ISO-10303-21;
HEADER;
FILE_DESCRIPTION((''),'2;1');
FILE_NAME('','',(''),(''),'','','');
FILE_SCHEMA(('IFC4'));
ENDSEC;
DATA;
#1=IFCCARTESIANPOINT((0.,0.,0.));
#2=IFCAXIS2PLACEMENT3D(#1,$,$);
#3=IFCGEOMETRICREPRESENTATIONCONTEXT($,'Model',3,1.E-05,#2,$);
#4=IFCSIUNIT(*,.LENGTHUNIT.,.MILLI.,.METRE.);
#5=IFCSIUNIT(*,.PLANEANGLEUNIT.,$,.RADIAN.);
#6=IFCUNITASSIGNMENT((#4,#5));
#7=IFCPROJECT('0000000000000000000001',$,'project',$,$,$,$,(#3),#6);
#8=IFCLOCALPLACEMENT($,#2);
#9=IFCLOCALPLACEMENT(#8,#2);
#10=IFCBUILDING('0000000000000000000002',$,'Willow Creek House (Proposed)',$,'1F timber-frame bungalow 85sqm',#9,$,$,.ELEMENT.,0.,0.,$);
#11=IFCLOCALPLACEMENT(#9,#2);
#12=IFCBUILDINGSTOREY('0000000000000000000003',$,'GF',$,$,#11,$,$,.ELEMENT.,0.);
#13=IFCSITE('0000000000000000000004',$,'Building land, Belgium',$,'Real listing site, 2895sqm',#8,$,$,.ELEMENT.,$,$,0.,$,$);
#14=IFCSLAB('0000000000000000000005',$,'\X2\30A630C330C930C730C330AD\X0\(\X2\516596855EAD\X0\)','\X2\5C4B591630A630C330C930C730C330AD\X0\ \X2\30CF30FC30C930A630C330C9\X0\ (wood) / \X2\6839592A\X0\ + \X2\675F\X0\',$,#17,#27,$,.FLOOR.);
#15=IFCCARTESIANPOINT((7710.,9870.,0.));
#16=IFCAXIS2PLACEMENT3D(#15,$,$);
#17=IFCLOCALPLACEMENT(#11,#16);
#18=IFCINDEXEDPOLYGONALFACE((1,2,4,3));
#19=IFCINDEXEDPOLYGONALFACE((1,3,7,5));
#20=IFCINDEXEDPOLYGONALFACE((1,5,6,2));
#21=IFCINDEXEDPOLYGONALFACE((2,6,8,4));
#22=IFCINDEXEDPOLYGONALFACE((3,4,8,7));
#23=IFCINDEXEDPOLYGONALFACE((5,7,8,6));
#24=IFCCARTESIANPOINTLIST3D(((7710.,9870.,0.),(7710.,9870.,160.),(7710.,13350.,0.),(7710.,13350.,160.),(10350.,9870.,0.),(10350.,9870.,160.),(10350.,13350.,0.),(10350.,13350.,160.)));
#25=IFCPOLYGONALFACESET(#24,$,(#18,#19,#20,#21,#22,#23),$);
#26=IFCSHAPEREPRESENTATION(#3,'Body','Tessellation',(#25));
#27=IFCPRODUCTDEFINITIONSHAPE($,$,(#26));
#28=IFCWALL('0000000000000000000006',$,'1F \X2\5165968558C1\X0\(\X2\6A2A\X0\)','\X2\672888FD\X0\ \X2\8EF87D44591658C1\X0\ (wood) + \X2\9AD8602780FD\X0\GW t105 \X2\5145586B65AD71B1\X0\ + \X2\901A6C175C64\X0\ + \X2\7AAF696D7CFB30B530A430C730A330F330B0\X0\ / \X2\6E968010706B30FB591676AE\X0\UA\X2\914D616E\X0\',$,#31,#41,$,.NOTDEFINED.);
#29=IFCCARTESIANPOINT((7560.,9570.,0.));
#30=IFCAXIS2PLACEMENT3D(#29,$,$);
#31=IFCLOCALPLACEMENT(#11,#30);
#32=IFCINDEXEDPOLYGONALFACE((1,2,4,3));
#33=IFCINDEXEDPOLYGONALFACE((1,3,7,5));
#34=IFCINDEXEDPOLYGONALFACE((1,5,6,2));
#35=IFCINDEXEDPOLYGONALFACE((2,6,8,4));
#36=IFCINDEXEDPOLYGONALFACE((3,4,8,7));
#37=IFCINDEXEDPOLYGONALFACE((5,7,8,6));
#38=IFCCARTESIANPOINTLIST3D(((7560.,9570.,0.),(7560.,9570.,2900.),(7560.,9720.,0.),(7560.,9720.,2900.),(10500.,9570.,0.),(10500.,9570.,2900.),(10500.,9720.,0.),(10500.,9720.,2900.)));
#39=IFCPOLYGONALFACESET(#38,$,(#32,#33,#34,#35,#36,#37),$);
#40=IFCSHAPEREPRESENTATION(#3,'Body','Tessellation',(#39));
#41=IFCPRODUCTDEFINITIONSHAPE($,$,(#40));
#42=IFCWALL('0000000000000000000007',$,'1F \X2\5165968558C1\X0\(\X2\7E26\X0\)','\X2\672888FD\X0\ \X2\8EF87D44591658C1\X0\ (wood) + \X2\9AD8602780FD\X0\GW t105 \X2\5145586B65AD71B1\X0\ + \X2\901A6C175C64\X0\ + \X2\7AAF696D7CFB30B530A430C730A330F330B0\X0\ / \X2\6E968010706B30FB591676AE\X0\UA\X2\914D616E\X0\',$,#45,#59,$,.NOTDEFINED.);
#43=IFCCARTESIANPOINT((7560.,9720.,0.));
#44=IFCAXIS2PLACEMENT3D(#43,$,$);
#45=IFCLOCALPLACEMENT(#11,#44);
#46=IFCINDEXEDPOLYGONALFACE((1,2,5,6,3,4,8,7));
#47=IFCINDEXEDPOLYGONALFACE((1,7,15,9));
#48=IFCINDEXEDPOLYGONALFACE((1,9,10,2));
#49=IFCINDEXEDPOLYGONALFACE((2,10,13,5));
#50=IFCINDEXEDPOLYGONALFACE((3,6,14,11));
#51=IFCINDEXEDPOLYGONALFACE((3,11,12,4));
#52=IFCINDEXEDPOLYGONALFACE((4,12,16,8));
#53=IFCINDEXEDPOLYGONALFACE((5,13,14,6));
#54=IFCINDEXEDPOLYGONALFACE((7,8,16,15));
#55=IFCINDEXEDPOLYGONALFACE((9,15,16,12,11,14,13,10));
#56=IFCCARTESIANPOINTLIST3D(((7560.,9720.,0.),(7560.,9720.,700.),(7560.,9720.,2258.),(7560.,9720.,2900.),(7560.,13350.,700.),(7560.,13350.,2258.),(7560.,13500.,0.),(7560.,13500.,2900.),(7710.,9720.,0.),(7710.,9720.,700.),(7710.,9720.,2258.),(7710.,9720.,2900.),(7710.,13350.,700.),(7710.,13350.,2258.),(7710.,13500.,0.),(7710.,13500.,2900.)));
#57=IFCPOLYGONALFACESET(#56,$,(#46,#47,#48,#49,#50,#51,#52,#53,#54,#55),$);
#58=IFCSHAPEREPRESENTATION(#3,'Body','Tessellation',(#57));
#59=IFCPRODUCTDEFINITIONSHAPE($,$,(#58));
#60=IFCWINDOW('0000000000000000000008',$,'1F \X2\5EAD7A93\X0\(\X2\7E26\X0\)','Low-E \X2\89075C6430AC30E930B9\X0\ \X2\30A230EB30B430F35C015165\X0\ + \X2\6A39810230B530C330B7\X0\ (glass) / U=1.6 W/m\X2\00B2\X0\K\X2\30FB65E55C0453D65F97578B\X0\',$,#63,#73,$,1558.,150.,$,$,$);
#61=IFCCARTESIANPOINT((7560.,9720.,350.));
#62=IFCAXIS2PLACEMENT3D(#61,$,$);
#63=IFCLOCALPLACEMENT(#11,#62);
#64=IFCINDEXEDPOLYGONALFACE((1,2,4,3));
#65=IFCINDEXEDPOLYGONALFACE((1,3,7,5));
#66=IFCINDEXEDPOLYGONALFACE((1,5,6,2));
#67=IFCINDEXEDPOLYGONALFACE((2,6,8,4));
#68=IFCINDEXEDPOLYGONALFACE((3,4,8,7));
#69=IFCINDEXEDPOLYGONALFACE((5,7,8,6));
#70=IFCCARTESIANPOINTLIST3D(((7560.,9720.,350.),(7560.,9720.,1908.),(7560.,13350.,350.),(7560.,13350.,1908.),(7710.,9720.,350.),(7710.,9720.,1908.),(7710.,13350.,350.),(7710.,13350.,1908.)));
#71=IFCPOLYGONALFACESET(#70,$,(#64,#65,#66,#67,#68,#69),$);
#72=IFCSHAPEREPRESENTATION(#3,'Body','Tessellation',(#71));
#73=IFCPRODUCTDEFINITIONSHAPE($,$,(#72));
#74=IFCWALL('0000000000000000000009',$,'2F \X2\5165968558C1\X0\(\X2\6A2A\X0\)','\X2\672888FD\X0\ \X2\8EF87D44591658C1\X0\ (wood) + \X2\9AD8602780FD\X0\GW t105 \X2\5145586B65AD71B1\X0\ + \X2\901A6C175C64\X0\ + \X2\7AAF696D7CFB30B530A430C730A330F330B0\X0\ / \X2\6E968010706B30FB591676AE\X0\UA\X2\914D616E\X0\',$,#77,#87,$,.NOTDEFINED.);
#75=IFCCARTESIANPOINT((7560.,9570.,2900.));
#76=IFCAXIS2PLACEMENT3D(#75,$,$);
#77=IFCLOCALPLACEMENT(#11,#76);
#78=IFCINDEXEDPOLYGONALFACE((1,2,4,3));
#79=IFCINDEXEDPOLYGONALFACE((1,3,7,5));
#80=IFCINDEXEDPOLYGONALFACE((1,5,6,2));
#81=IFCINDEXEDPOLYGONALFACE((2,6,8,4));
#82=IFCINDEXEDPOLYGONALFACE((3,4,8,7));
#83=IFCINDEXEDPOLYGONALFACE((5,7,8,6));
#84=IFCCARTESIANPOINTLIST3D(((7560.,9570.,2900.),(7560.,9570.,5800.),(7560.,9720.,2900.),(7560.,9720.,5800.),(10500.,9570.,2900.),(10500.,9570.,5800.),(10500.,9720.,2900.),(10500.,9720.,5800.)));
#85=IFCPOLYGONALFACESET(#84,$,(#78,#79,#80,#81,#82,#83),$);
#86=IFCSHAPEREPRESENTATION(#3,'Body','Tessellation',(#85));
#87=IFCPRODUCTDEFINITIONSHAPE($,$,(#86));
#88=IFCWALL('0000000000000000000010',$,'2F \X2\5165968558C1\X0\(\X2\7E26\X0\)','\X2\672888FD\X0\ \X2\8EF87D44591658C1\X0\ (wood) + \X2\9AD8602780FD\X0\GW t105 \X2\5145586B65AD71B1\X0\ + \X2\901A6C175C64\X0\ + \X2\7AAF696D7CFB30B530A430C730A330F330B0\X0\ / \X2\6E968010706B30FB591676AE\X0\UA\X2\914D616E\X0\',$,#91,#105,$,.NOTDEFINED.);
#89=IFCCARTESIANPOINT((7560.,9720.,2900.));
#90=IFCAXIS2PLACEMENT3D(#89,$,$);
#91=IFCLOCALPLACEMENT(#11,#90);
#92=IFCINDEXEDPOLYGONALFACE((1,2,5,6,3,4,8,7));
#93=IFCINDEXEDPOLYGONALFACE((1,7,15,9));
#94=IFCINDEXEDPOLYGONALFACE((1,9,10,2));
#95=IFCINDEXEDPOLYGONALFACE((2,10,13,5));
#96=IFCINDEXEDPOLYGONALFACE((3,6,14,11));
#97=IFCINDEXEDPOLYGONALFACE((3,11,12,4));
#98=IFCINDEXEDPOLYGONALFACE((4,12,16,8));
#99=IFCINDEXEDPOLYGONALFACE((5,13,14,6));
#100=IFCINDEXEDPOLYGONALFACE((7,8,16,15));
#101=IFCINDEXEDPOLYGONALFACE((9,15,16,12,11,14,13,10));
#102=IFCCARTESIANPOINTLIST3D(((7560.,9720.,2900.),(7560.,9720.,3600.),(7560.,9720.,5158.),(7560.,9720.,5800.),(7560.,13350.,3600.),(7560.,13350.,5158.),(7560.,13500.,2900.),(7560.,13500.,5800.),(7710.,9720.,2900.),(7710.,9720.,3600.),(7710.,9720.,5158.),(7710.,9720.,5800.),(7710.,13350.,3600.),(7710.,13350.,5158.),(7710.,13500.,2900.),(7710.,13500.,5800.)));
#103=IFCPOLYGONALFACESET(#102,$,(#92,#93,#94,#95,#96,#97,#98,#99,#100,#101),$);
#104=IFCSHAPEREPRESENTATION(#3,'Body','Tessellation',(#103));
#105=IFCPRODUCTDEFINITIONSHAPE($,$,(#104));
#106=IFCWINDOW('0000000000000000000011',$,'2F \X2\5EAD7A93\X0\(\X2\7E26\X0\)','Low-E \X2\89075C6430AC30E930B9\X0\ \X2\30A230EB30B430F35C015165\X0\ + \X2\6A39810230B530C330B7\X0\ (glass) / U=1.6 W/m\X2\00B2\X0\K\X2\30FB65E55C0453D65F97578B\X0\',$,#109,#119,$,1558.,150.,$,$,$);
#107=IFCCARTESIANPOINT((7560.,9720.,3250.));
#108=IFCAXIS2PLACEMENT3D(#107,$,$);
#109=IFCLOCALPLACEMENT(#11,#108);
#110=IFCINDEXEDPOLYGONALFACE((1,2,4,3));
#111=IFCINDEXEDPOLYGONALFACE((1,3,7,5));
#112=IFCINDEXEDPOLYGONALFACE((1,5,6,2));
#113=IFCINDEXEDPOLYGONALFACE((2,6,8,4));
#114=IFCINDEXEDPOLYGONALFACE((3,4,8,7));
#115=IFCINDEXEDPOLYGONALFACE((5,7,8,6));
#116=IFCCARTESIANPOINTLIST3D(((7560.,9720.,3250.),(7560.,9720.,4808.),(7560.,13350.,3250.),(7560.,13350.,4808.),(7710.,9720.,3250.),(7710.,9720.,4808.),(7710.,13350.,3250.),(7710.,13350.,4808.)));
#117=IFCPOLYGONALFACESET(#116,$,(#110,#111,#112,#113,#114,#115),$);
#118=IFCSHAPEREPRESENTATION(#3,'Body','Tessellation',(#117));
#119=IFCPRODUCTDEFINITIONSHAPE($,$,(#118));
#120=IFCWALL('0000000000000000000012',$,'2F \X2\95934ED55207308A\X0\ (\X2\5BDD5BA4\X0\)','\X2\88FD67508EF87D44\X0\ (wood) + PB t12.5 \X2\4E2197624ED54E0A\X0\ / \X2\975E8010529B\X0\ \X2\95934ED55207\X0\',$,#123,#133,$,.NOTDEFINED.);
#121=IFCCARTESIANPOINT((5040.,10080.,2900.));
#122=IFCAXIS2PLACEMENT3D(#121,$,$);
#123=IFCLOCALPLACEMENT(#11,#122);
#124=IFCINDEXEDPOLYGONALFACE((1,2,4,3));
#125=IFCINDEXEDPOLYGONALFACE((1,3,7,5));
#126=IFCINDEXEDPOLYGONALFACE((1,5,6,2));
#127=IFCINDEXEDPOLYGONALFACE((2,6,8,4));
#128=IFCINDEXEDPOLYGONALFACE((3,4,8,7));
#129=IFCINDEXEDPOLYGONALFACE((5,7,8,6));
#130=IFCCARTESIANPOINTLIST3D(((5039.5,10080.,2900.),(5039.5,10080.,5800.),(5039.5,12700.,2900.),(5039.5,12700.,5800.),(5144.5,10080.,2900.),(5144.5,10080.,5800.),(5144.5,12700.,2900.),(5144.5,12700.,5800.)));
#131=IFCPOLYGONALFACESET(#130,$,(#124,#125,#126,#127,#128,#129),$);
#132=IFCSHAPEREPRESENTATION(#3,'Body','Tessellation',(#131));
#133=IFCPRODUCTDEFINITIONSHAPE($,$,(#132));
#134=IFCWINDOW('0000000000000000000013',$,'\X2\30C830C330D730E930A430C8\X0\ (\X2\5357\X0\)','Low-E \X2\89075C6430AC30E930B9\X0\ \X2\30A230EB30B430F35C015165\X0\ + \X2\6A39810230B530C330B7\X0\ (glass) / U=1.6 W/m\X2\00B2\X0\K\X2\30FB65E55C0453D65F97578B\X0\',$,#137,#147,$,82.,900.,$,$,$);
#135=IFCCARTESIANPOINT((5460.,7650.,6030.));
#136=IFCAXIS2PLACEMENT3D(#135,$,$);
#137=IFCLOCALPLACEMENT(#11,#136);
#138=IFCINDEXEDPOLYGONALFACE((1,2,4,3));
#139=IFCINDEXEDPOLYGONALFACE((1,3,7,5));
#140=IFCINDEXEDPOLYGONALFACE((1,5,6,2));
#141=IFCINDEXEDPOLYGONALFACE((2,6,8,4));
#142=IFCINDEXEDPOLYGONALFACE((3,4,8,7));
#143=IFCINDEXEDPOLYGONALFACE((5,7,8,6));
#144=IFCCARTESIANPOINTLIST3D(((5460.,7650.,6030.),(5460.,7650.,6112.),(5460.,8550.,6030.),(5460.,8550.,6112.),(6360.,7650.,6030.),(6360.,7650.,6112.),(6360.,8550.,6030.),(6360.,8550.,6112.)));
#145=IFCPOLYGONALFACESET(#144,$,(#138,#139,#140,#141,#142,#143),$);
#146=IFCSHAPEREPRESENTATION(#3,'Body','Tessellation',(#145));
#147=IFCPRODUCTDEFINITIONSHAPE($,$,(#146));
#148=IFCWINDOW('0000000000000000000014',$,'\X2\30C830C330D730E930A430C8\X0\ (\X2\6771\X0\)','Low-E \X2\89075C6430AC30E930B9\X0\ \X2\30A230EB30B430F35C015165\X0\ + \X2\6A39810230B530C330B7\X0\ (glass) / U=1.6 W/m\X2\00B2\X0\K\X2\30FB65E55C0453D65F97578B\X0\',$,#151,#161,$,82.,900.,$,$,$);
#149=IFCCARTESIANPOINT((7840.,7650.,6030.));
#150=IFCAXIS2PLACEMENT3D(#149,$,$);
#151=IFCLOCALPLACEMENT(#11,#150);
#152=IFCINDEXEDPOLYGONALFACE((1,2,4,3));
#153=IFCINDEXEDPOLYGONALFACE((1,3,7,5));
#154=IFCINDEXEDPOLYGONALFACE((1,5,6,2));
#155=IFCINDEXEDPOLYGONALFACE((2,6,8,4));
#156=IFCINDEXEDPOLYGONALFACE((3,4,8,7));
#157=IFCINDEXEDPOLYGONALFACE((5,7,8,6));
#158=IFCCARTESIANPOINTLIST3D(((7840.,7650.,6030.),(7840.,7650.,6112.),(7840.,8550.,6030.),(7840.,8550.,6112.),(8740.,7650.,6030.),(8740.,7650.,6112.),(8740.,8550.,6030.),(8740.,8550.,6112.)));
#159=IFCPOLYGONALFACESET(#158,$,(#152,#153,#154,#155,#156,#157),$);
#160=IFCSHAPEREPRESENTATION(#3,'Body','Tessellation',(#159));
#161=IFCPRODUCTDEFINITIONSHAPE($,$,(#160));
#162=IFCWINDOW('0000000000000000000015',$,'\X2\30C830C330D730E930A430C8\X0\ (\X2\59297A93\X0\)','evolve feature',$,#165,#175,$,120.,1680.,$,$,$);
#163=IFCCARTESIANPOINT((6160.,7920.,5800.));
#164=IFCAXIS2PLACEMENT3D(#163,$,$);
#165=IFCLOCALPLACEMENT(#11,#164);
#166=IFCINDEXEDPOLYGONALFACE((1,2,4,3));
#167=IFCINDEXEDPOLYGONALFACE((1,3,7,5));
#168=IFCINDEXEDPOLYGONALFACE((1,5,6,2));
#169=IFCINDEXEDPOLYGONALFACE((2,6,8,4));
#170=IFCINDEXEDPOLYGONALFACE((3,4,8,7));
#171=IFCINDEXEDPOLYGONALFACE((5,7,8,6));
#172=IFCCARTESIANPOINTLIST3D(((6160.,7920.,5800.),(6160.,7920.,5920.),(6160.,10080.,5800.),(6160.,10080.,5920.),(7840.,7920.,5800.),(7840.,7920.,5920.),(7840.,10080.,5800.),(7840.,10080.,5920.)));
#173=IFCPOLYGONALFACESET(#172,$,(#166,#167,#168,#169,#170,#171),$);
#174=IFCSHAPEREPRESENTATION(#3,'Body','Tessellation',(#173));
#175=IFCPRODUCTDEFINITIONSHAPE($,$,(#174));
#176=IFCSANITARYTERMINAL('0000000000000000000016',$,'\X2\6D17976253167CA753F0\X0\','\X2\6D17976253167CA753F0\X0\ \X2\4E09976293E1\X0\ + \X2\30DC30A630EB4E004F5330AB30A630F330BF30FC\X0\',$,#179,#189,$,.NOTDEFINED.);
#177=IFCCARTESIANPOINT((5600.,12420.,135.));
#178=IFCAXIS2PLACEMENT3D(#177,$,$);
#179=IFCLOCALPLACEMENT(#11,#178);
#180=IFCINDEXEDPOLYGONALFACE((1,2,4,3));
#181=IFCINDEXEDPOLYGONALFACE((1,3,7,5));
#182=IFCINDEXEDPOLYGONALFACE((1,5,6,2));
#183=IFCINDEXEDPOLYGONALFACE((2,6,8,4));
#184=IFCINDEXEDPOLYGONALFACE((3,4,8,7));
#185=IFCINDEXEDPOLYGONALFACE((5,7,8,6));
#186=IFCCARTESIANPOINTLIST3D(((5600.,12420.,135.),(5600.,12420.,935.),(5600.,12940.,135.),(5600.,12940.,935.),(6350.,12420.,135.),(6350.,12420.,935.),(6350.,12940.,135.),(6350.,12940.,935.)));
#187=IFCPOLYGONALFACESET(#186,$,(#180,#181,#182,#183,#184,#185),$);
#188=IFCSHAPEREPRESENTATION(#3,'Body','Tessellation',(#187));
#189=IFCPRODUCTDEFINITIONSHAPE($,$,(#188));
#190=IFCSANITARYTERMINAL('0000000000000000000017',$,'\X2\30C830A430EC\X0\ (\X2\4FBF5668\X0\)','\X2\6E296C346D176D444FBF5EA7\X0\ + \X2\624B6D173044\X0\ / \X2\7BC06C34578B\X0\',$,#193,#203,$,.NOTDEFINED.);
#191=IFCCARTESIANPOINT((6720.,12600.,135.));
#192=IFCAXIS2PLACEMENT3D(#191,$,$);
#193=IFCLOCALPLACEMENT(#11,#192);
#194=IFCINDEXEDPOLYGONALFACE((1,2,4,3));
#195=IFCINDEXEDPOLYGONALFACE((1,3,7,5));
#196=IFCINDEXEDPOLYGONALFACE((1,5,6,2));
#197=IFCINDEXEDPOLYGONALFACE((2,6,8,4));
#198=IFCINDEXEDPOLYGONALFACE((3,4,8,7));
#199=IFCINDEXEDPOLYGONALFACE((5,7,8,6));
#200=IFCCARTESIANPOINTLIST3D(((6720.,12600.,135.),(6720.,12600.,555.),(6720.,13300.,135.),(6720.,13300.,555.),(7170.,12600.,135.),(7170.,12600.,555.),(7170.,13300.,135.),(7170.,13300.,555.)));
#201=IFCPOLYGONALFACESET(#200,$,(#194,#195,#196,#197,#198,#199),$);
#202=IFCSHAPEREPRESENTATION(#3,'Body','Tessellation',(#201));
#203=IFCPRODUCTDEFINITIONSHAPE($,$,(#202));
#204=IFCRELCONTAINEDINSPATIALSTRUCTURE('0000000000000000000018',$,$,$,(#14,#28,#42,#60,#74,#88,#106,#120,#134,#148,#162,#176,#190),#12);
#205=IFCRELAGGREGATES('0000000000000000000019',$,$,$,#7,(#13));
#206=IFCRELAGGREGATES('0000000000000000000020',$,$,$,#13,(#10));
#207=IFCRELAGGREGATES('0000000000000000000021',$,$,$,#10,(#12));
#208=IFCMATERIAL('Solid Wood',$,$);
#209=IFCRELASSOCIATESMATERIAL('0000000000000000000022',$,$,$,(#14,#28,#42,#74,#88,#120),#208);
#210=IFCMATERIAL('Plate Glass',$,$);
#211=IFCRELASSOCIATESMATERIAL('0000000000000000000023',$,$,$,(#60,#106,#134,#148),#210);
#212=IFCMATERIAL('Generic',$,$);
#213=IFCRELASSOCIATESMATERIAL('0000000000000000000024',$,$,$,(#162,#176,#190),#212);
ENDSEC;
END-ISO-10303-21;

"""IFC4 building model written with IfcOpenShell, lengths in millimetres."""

from ifc_helpers import new_model, si_unit, frame, frame_2d, origin, place, context, project, spatial, rectangle, extrude, material, element, fill, save


model = new_model("IFC4")

# Units and contexts
model_context = context("Model", 3, precision=1e-05, world=origin())
ifc_project = project(units=[si_unit("LENGTHUNIT", "METRE", prefix="MILLI"), si_unit("PLANEANGLEUNIT", "RADIAN")], contexts=[model_context])

# Site, building, storey
site_placement = place(None, origin())
site = spatial("IfcSite", under=ifc_project, at=site_placement, Name="Building land, Belgium", ObjectType="Real listing site, 2895sqm", CompositionType="ELEMENT", RefElevation=0.0)
building_placement = place(site_placement, origin())
building = spatial("IfcBuilding", under=site, at=building_placement, Name="Willow Creek House (Proposed)", ObjectType="1F timber-frame bungalow 85sqm", CompositionType="ELEMENT", ElevationOfRefHeight=0.0, ElevationOfTerrain=0.0)
storey_placement = place(building_placement, origin())
storey = spatial("IfcBuildingStorey", under=building, at=storey_placement, Name="GF", CompositionType="ELEMENT", Elevation=0.0)

# Slab
ifc_material_1 = material(Name="Solid Wood")
slab_placement = place(storey_placement, frame((7710.0, 9870.0, 0.0)))
element("IfcSlab", 1, at=slab_placement, inside=storey, material=ifc_material_1, Name="ウッドデッキ(入隅庭)", Description="屋外ウッドデッキ ハードウッド (wood) / 根太 + 束", PredefinedType="FLOOR", context=model_context, shape_type="SweptSolid", body=[
    extrude(rectangle(XDim=2640.0, YDim=3480.0, at=frame_2d((1320.0, 1740.0))), frame((7710.0, 9870.0, 0.0)), (0.0, 0.0, 1.0), 160.0),
])

# Wall
wall_1_placement = place(storey_placement, frame((7560.0, 9570.0, 0.0)))
element("IfcWall", 2, at=wall_1_placement, inside=storey, material=ifc_material_1, Name="1F 入隅壁(横)", Description="木製 軸組外壁 (wood) + 高性能GW t105 充填断熱 + 通気層 + 窯業系サイディング / 準耐火・外皮UA配慮", PredefinedType="NOTDEFINED", context=model_context, shape_type="SweptSolid", body=[
    extrude(rectangle(XDim=2940.0, YDim=150.0, at=frame_2d((1470.0, 75.0))), frame((7560.0, 9570.0, 0.0)), (0.0, 0.0, 1.0), 2900.0),
])

# Wall, opening, window
wall_2_placement = place(storey_placement, frame((7560.0, 9720.0, 0.0)))
wall_2 = element("IfcWall", 3, at=wall_2_placement, inside=storey, material=ifc_material_1, Name="1F 入隅壁(縦)", Description="木製 軸組外壁 (wood) + 高性能GW t105 充填断熱 + 通気層 + 窯業系サイディング / 準耐火・外皮UA配慮", PredefinedType="NOTDEFINED", context=model_context, shape_type="SweptSolid", body=[
    extrude(rectangle(XDim=150.0, YDim=3780.0, at=frame_2d((75.0, 1890.0))), frame((7560.0, 9720.0, 0.0)), (0.0, 0.0, 1.0), 2900.0),
])
opening_1_placement = place(storey_placement, frame((7560.0, 9720.0, 350.0)))
opening_1 = element("IfcOpeningElement", 4, at=opening_1_placement, cuts=wall_2, PredefinedType="NOTDEFINED", context=model_context, shape_type="SweptSolid", body=[
    extrude(rectangle(XDim=150.0, YDim=3630.0, at=frame_2d((75.0, 1815.0))), frame((7560.0, 9720.0, 350.0)), (0.0, 0.0, 1.0), 1558.0),
])
ifc_material_2 = material(Name="Plate Glass")
window_1_placement = place(storey_placement, frame((7560.0, 9720.0, 350.0)))
window_1 = element("IfcWindow", 5, at=window_1_placement, inside=storey, material=ifc_material_2, Name="1F 庭窓(縦)", Description="Low-E 複層ガラス アルゴン封入 + 樹脂サッシ (glass) / U=1.6 W/m²K・日射取得型", OverallHeight=1558.0, OverallWidth=150.0, context=model_context, shape_type="SweptSolid", body=[
    extrude(rectangle(XDim=150.0, YDim=3630.0, at=frame_2d((75.0, 1815.0))), frame((7560.0, 9720.0, 350.0)), (0.0, 0.0, 1.0), 1558.0),
])
fill(opening_1, window_1)

# Wall
wall_3_placement = place(storey_placement, frame((7560.0, 9570.0, 2900.0)))
element("IfcWall", 6, at=wall_3_placement, inside=storey, material=ifc_material_1, Name="2F 入隅壁(横)", Description="木製 軸組外壁 (wood) + 高性能GW t105 充填断熱 + 通気層 + 窯業系サイディング / 準耐火・外皮UA配慮", PredefinedType="NOTDEFINED", context=model_context, shape_type="SweptSolid", body=[
    extrude(rectangle(XDim=2940.0, YDim=150.0, at=frame_2d((1470.0, 75.0))), frame((7560.0, 9570.0, 2900.0)), (0.0, 0.0, 1.0), 2900.0),
])

# Wall, opening, window
wall_4_placement = place(storey_placement, frame((7560.0, 9720.0, 2900.0)))
wall_4 = element("IfcWall", 7, at=wall_4_placement, inside=storey, material=ifc_material_1, Name="2F 入隅壁(縦)", Description="木製 軸組外壁 (wood) + 高性能GW t105 充填断熱 + 通気層 + 窯業系サイディング / 準耐火・外皮UA配慮", PredefinedType="NOTDEFINED", context=model_context, shape_type="SweptSolid", body=[
    extrude(rectangle(XDim=150.0, YDim=3780.0, at=frame_2d((75.0, 1890.0))), frame((7560.0, 9720.0, 2900.0)), (0.0, 0.0, 1.0), 2900.0),
])
opening_2_placement = place(storey_placement, frame((7560.0, 9720.0, 3250.0)))
opening_2 = element("IfcOpeningElement", 8, at=opening_2_placement, cuts=wall_4, PredefinedType="NOTDEFINED", context=model_context, shape_type="SweptSolid", body=[
    extrude(rectangle(XDim=150.0, YDim=3630.0, at=frame_2d((75.0, 1815.0))), frame((7560.0, 9720.0, 3250.0)), (0.0, 0.0, 1.0), 1558.0),
])
window_2_placement = place(storey_placement, frame((7560.0, 9720.0, 3250.0)))
window_2 = element("IfcWindow", 9, at=window_2_placement, inside=storey, material=ifc_material_2, Name="2F 庭窓(縦)", Description="Low-E 複層ガラス アルゴン封入 + 樹脂サッシ (glass) / U=1.6 W/m²K・日射取得型", OverallHeight=1558.0, OverallWidth=150.0, context=model_context, shape_type="SweptSolid", body=[
    extrude(rectangle(XDim=150.0, YDim=3630.0, at=frame_2d((75.0, 1815.0))), frame((7560.0, 9720.0, 3250.0)), (0.0, 0.0, 1.0), 1558.0),
])
fill(opening_2, window_2)

# Wall
wall_5_placement = place(storey_placement, frame((5040.0, 10080.0, 2900.0)))
element("IfcWall", 10, at=wall_5_placement, inside=storey, material=ifc_material_1, Name="2F 間仕切り (寝室)", Description="製材軸組 (wood) + PB t12.5 両面仕上 / 非耐力 間仕切", PredefinedType="NOTDEFINED", context=model_context, shape_type="SweptSolid", body=[
    extrude(rectangle(XDim=105.0, YDim=2620.0, at=frame_2d((52.0, 1310.0))), frame((5040.0, 10080.0, 2900.0)), (0.0, 0.0, 1.0), 2900.0),
])

# Windows
window_3_placement = place(storey_placement, frame((5460.0, 7650.0, 6030.0)))
element("IfcWindow", 11, at=window_3_placement, inside=storey, material=ifc_material_2, Name="トップライト (南)", Description="Low-E 複層ガラス アルゴン封入 + 樹脂サッシ (glass) / U=1.6 W/m²K・日射取得型", OverallHeight=82.0, OverallWidth=900.0, context=model_context, shape_type="SweptSolid", body=[
    extrude(rectangle(XDim=900.0, YDim=900.0, at=frame_2d((450.0, 450.0))), frame((5460.0, 7650.0, 6030.0)), (0.0, 0.0, 1.0), 82.0),
])
window_4_placement = place(storey_placement, frame((7840.0, 7650.0, 6030.0)))
element("IfcWindow", 12, at=window_4_placement, inside=storey, material=ifc_material_2, Name="トップライト (東)", Description="Low-E 複層ガラス アルゴン封入 + 樹脂サッシ (glass) / U=1.6 W/m²K・日射取得型", OverallHeight=82.0, OverallWidth=900.0, context=model_context, shape_type="SweptSolid", body=[
    extrude(rectangle(XDim=900.0, YDim=900.0, at=frame_2d((450.0, 450.0))), frame((7840.0, 7650.0, 6030.0)), (0.0, 0.0, 1.0), 82.0),
])
ifc_material_3 = material(Name="Generic")
window_5_placement = place(storey_placement, frame((6160.0, 7920.0, 5800.0)))
element("IfcWindow", 13, at=window_5_placement, inside=storey, material=ifc_material_3, Name="トップライト (天窓)", Description="evolve feature", OverallHeight=120.0, OverallWidth=1680.0, context=model_context, shape_type="SweptSolid", body=[
    extrude(rectangle(XDim=1680.0, YDim=2160.0, at=frame_2d((840.0, 1080.0))), frame((6160.0, 7920.0, 5800.0)), (0.0, 0.0, 1.0), 120.0),
])

# Sanitary terminals
sanitary_terminal_1_placement = place(storey_placement, frame((5600.0, 12420.0, 135.0)))
element("IfcSanitaryTerminal", 14, at=sanitary_terminal_1_placement, inside=storey, material=ifc_material_3, Name="洗面化粧台", Description="洗面化粧台 三面鏡 + ボウル一体カウンター", PredefinedType="NOTDEFINED", context=model_context, shape_type="SweptSolid", body=[
    extrude(rectangle(XDim=750.0, YDim=520.0, at=frame_2d((375.0, 260.0))), frame((5600.0, 12420.0, 135.0)), (0.0, 0.0, 1.0), 800.0),
])
sanitary_terminal_2_placement = place(storey_placement, frame((6720.0, 12600.0, 135.0)))
element("IfcSanitaryTerminal", 15, at=sanitary_terminal_2_placement, inside=storey, material=ifc_material_3, Name="トイレ (便器)", Description="温水洗浄便座 + 手洗い / 節水型", PredefinedType="NOTDEFINED", context=model_context, shape_type="SweptSolid", body=[
    extrude(rectangle(XDim=450.0, YDim=700.0, at=frame_2d((225.0, 350.0))), frame((6720.0, 12600.0, 135.0)), (0.0, 0.0, 1.0), 420.0),
])

save(model, "model.ifc")
